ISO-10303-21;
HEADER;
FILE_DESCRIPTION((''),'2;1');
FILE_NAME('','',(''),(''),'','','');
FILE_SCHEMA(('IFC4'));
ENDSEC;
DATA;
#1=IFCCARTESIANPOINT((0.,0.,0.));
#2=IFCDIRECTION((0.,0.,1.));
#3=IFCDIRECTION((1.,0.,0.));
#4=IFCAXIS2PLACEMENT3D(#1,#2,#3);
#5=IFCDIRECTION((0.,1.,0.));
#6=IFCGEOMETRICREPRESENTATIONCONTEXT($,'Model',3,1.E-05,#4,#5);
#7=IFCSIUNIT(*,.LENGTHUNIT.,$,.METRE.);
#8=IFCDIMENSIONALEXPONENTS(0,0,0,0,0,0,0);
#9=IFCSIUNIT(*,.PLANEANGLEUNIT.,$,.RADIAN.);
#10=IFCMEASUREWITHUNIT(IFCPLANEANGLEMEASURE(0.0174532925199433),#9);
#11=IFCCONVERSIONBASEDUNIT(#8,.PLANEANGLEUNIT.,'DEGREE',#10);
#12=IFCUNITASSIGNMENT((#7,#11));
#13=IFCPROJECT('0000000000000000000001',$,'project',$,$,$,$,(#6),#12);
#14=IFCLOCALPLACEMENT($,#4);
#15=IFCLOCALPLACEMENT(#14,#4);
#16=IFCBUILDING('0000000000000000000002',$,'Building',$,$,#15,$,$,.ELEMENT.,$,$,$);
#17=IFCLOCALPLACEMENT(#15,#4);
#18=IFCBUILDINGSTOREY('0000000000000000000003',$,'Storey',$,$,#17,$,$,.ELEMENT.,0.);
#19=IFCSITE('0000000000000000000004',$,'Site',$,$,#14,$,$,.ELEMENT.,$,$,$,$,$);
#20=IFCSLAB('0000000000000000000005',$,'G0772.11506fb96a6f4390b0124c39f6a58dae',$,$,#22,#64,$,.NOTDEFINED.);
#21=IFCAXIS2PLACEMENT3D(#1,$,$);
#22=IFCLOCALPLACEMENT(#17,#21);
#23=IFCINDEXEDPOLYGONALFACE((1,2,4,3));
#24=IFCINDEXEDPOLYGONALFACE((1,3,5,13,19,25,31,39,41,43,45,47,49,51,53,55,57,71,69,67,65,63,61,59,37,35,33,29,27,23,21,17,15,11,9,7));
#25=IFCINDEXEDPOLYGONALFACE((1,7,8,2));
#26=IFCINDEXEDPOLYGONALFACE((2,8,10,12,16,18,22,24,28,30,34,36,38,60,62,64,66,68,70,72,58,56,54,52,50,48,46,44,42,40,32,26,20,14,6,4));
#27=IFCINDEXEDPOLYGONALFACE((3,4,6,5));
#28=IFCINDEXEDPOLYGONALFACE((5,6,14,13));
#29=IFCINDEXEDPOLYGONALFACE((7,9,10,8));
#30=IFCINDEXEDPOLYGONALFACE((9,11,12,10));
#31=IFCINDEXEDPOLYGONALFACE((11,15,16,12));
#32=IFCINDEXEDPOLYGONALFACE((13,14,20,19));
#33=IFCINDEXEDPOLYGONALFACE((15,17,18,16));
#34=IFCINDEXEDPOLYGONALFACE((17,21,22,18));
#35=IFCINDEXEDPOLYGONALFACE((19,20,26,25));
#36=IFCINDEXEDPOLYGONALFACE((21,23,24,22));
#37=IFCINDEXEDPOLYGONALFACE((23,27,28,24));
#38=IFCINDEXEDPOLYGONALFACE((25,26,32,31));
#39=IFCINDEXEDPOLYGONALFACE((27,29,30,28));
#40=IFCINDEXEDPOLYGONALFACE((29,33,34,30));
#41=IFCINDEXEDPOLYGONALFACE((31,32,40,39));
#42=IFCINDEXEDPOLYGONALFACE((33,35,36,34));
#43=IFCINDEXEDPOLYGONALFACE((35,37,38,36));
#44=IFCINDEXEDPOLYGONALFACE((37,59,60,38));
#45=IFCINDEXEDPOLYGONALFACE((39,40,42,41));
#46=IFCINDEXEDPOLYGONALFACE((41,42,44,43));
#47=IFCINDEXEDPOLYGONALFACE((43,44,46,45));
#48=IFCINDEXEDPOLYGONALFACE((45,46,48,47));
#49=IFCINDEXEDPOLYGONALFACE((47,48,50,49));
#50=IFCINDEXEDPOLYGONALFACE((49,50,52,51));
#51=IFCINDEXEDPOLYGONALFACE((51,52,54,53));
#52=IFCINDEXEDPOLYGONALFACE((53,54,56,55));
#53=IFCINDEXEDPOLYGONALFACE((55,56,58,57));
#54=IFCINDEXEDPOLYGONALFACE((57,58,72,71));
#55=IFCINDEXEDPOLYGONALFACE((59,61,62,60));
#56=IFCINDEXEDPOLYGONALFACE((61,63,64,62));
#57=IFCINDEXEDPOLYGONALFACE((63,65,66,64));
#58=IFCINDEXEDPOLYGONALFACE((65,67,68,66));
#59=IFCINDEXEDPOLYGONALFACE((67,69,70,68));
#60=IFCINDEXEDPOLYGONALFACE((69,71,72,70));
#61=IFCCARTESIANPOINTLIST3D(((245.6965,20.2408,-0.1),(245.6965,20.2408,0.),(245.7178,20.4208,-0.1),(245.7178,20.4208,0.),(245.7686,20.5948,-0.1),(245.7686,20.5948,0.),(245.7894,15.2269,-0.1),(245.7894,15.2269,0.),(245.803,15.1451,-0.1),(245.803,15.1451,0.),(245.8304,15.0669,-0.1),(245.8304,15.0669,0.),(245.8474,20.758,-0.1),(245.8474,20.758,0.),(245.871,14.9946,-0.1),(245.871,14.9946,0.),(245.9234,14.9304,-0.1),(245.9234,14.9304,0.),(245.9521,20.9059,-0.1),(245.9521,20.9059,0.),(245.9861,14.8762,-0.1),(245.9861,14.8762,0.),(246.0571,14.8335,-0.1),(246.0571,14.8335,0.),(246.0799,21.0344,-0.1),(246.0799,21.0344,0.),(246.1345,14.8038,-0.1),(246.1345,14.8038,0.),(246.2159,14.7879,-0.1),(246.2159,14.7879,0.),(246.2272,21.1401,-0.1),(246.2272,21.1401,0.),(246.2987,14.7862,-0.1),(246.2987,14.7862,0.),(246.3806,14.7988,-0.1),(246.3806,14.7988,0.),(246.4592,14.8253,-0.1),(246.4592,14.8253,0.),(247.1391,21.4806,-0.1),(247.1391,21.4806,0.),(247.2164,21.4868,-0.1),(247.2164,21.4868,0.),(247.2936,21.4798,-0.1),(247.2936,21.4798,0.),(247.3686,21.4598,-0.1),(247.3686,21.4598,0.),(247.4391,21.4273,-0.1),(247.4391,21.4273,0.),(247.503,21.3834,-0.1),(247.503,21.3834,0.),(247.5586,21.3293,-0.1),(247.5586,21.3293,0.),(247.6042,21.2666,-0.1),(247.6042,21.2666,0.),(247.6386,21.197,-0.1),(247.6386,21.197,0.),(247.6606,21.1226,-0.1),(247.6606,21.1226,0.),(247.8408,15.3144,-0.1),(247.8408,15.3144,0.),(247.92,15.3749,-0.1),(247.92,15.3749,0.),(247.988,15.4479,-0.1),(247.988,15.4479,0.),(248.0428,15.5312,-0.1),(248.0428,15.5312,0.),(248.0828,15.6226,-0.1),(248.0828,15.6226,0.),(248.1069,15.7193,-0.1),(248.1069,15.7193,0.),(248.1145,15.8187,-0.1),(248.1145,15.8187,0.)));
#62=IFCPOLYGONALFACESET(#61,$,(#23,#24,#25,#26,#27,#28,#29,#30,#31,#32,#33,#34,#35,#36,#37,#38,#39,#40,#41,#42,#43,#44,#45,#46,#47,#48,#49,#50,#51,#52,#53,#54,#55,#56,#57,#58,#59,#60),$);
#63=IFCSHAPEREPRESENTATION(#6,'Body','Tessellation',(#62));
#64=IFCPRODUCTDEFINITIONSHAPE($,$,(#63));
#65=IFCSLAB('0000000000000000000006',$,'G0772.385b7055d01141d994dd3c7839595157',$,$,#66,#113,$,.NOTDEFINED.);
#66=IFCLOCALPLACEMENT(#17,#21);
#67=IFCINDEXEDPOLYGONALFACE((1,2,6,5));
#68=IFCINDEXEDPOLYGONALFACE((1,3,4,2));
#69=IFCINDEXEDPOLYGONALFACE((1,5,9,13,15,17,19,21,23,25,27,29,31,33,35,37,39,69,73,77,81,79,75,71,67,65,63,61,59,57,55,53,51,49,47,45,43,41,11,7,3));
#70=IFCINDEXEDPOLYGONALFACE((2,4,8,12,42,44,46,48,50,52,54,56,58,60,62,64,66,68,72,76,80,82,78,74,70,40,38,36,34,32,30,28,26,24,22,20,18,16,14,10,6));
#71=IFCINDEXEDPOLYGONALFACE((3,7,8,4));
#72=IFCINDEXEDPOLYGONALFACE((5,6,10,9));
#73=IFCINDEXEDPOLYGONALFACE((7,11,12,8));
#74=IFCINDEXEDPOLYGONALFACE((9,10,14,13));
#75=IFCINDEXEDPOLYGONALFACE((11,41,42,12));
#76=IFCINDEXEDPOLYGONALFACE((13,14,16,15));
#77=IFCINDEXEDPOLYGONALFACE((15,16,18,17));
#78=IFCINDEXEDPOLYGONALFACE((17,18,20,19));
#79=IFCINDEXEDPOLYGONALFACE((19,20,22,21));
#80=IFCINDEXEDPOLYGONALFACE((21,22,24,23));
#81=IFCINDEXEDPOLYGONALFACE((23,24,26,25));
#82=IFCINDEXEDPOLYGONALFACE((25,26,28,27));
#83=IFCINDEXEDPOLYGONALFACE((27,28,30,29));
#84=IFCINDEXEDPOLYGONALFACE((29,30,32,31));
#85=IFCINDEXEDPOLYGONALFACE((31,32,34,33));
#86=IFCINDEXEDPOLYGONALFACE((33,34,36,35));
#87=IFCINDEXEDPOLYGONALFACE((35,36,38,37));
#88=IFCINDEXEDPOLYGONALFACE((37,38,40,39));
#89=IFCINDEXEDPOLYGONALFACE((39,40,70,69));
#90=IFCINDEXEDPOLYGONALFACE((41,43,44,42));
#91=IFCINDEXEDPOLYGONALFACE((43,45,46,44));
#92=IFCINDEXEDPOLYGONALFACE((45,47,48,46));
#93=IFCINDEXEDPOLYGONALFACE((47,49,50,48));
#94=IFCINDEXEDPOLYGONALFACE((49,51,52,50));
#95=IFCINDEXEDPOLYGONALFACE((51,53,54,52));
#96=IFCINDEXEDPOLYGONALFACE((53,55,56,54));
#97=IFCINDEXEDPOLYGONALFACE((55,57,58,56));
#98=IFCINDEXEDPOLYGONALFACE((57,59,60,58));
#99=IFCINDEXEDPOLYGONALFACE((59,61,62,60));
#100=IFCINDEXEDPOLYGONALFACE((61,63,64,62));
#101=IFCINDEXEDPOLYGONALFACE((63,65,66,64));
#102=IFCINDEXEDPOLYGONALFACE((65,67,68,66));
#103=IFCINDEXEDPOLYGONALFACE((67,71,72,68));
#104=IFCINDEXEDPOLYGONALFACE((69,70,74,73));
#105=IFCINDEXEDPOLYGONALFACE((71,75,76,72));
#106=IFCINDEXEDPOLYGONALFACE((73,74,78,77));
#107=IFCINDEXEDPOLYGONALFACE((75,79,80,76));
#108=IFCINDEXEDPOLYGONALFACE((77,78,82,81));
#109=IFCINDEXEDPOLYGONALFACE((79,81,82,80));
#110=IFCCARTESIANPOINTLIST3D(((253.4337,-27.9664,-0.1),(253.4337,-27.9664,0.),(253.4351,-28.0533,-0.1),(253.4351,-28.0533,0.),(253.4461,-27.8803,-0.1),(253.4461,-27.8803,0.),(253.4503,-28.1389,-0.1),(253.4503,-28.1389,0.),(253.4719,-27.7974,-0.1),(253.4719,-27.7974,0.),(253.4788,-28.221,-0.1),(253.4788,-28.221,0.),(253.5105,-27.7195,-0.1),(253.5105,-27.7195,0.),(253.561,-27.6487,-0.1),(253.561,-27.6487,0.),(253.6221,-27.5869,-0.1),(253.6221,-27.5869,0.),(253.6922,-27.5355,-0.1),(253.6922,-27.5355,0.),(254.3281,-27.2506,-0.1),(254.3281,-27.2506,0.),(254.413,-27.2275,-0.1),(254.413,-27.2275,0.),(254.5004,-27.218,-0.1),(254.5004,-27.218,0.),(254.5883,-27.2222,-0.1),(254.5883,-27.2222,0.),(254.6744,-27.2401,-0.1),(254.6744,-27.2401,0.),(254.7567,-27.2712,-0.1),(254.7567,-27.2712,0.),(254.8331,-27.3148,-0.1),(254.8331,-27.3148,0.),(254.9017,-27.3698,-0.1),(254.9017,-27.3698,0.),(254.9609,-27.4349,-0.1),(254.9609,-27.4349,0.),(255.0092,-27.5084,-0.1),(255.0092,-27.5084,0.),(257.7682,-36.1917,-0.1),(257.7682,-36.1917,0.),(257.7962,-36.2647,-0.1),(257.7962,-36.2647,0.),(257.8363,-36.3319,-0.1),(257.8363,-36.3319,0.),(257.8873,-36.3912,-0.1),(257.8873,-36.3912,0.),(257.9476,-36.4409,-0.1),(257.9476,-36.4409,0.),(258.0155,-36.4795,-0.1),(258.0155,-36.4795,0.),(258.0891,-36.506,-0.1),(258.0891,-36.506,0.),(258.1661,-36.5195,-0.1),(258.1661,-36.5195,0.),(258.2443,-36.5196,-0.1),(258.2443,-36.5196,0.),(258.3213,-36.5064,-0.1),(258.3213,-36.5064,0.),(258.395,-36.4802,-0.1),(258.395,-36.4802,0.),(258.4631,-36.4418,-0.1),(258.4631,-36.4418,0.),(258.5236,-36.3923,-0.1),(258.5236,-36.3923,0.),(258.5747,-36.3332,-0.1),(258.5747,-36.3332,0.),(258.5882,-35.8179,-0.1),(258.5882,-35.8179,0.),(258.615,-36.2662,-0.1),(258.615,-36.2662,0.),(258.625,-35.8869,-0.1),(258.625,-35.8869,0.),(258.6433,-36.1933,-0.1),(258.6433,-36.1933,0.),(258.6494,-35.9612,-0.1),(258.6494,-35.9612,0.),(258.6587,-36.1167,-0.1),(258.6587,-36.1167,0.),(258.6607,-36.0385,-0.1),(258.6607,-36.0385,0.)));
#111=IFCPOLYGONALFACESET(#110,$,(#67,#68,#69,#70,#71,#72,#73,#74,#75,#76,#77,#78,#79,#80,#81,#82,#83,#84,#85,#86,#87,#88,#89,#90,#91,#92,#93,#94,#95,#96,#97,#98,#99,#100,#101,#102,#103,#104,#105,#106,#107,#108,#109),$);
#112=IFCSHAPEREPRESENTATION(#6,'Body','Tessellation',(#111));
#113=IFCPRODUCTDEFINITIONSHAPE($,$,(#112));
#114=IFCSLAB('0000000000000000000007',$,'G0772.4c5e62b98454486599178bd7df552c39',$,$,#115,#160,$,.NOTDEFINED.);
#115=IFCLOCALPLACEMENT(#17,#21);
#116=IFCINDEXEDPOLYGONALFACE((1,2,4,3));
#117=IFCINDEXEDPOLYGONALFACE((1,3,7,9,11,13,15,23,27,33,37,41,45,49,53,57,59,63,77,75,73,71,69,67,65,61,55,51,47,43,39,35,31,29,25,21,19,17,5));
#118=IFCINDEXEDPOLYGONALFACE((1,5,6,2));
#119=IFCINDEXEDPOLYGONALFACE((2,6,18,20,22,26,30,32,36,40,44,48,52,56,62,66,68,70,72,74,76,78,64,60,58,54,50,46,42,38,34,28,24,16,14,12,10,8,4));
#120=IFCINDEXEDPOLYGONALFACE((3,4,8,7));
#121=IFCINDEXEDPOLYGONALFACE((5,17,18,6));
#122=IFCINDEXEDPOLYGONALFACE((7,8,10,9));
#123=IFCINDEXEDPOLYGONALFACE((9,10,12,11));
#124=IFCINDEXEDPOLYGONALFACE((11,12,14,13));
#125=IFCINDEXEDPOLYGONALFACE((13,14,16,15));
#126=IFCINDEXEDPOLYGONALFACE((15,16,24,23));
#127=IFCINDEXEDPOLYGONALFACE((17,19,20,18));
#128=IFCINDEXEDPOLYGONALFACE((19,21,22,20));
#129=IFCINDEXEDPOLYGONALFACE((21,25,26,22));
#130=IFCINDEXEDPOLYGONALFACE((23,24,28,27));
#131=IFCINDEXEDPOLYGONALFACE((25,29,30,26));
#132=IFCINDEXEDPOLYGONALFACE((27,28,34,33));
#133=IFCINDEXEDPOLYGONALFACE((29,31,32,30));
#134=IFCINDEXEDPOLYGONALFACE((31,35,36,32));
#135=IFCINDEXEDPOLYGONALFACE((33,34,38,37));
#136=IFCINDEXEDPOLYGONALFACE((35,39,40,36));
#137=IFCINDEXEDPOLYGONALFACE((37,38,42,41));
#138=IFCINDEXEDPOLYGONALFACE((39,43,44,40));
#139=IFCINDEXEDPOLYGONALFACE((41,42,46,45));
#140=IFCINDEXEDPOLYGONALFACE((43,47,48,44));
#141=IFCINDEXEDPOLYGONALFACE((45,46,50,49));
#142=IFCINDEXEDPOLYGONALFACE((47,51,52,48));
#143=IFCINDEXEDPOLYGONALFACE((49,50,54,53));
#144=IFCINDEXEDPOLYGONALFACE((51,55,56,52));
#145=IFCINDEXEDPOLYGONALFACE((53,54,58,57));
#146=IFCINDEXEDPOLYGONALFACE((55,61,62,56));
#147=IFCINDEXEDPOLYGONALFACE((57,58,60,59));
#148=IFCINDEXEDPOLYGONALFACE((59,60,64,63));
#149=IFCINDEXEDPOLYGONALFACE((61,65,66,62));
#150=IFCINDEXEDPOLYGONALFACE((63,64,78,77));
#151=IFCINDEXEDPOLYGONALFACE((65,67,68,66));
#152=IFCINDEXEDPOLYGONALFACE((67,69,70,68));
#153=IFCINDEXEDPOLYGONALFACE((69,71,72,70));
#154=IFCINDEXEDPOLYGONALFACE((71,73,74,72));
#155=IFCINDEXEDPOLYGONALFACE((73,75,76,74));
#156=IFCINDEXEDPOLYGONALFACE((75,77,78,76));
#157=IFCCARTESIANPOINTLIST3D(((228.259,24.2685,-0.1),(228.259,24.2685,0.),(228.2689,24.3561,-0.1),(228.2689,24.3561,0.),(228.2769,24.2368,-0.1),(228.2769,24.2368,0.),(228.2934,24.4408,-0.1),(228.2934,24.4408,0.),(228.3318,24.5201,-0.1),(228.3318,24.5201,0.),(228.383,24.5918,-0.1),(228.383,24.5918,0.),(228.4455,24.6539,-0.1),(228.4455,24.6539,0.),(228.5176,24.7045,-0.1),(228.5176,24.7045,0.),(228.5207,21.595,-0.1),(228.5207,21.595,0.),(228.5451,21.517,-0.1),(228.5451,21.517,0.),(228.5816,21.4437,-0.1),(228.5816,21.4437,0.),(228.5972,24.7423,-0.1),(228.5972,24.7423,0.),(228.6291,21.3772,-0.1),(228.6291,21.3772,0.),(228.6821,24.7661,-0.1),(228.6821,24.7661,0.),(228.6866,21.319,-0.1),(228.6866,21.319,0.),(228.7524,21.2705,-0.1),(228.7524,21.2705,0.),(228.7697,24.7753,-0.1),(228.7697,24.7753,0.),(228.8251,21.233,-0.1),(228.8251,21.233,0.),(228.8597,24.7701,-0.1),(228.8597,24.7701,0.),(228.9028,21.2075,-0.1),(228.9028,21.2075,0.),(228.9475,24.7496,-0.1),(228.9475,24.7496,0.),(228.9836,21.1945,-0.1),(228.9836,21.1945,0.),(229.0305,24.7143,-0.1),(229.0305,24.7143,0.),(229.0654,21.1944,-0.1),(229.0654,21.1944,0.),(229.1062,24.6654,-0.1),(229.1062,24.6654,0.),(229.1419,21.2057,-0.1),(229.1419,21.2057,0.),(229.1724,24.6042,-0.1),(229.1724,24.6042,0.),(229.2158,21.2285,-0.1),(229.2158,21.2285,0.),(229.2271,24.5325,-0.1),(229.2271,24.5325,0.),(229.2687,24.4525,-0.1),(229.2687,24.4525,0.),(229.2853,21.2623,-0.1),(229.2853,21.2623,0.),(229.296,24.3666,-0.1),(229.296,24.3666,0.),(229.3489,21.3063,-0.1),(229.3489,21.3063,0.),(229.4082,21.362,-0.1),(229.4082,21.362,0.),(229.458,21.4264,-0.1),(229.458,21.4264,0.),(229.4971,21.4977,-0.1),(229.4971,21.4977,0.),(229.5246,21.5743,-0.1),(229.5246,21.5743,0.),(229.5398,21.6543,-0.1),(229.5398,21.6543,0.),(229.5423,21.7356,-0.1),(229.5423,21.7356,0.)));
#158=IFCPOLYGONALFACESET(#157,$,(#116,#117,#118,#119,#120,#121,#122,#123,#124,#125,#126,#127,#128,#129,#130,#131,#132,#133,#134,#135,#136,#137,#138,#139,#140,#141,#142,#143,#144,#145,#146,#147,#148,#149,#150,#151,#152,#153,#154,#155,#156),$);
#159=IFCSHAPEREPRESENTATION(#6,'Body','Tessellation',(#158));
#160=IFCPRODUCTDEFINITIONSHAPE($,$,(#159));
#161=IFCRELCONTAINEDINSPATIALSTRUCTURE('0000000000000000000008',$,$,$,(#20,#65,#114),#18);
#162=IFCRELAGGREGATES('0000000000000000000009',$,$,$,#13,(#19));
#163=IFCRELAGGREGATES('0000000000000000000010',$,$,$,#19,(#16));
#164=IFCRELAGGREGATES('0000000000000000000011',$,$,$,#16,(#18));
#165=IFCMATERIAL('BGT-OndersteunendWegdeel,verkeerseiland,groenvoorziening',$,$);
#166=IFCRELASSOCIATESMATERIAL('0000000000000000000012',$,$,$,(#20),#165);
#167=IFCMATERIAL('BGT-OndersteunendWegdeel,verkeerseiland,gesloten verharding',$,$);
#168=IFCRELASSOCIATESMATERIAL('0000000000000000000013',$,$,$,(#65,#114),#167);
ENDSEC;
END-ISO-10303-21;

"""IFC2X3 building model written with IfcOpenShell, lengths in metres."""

from ifc_helpers import new_model, entity, si_unit, converted_unit, direction, frame, origin_with_axes, place, context, project, spatial, polyline, outline, extrude, material, element, save


model = new_model("IFC2X3")

# Units and contexts
model_context = context("Model", 3, precision=1e-05, world=origin_with_axes(), true_north=direction((0.0, 1.0, 0.0)))
ifc_project = project(units=[si_unit("LENGTHUNIT", "METRE"), converted_unit("PLANEANGLEUNIT", "DEGREE", entity("IfcPlaneAngleMeasure", 0.0174532925199433), si_unit("PLANEANGLEUNIT", "RADIAN"), dimensions=[0, 0, 0, 0, 0, 0, 0])], contexts=[model_context])

# Site, building, storey
site_placement = place(None, origin_with_axes())
site = spatial("IfcSite", under=ifc_project, at=site_placement, Name="Site", CompositionType="ELEMENT")
building_placement = place(site_placement, origin_with_axes())
building = spatial("IfcBuilding", under=site, at=building_placement, Name="Building", CompositionType="ELEMENT")
storey_placement = place(building_placement, origin_with_axes())
storey = spatial("IfcBuildingStorey", under=building, at=storey_placement, Name="Storey", CompositionType="ELEMENT", Elevation=0.0)

# Slabs
ifc_material_1 = material(Name="BGT-OndersteunendWegdeel,verkeerseiland,gesloten verharding")
ifc_material_2 = material(Name="BGT-OndersteunendWegdeel,verkeerseiland,groenvoorziening")
slab_1_placement = place(storey_placement, frame((0.0, 0.0, -0.1), z_axis=(0.0, 0.0, 1.0), x_axis=(1.0, 0.0, 0.0)))
element("IfcSlab", 1, at=slab_1_placement, inside=storey, material=ifc_material_2, Name="G0772.11506fb96a6f4390b0124c39f6a58dae", PredefinedType="NOTDEFINED", context=model_context, shape_type="SweptSolid", body=[
    extrude(outline(polyline([(245.6965, 20.2408), (245.7178, 20.4208), (245.7686, 20.5948), (245.8474, 20.758), (245.9521, 20.9059), (246.0799, 21.0344), (246.2272, 21.1401), (247.1391, 21.4806), (247.2164, 21.4868), (247.2936, 21.4798), (247.3686, 21.4598), (247.4391, 21.4273), (247.503, 21.3834), (247.5586, 21.3293), (247.6042, 21.2666), (247.6386, 21.197), (247.6606, 21.1226), (248.1145, 15.8187), (248.1069, 15.7193), (248.0828, 15.6226), (248.0428, 15.5312), (247.988, 15.4479), (247.92, 15.3749), (247.8408, 15.3144), (246.4592, 14.8253), (246.3806, 14.7988), (246.2987, 14.7862), (246.2159, 14.7879), (246.1345, 14.8038), (246.0571, 14.8335), (245.9861, 14.8762), (245.9234, 14.9304), (245.871, 14.9946), (245.8304, 15.0669), (245.803, 15.1451), (245.7894, 15.2269), (245.6965, 20.2408)])), origin_with_axes(), (0.0, 0.0, 1.0), 0.1),
])
slab_2_placement = place(storey_placement, frame((0.0, 0.0, -0.1), z_axis=(0.0, 0.0, 1.0), x_axis=(1.0, 0.0, 0.0)))
element("IfcSlab", 2, at=slab_2_placement, inside=storey, material=ifc_material_1, Name="G0772.385b7055d01141d994dd3c7839595157", PredefinedType="NOTDEFINED", context=model_context, shape_type="SweptSolid", body=[
    extrude(outline(polyline([(253.4788, -28.221), (253.4503, -28.1389), (253.4351, -28.0533), (253.4337, -27.9664), (253.4461, -27.8803), (253.4719, -27.7974), (253.5105, -27.7195), (253.561, -27.6487), (253.6221, -27.5869), (253.6922, -27.5355), (254.3281, -27.2506), (254.413, -27.2275), (254.5004, -27.218), (254.5883, -27.2222), (254.6744, -27.2401), (254.7567, -27.2712), (254.8331, -27.3148), (254.9017, -27.3698), (254.9609, -27.4349), (255.0092, -27.5084), (258.5882, -35.8179), (258.625, -35.8869), (258.6494, -35.9612), (258.6607, -36.0385), (258.6587, -36.1167), (258.6433, -36.1933), (258.615, -36.2662), (258.5747, -36.3332), (258.5236, -36.3923), (258.4631, -36.4418), (258.395, -36.4802), (258.3213, -36.5064), (258.2443, -36.5196), (258.1661, -36.5195), (258.0891, -36.506), (258.0155, -36.4795), (257.9476, -36.4409), (257.8873, -36.3912), (257.8363, -36.3319), (257.7962, -36.2647), (257.7682, -36.1917), (253.4788, -28.221)])), origin_with_axes(), (0.0, 0.0, 1.0), 0.1),
])
slab_3_placement = place(storey_placement, frame((0.0, 0.0, -0.1), z_axis=(0.0, 0.0, 1.0), x_axis=(1.0, 0.0, 0.0)))
element("IfcSlab", 3, at=slab_3_placement, inside=storey, material=ifc_material_1, Name="G0772.4c5e62b98454486599178bd7df552c39", PredefinedType="NOTDEFINED", context=model_context, shape_type="SweptSolid", body=[
    extrude(outline(polyline([(228.8597, 24.7701), (228.9475, 24.7496), (229.0305, 24.7143), (229.1062, 24.6654), (229.1724, 24.6042), (229.2271, 24.5325), (229.2687, 24.4525), (229.296, 24.3666), (229.5423, 21.7356), (229.5398, 21.6543), (229.5246, 21.5743), (229.4971, 21.4977), (229.458, 21.4264), (229.4082, 21.362), (229.3489, 21.3063), (229.2853, 21.2623), (229.2158, 21.2285), (229.1419, 21.2057), (229.0654, 21.1944), (228.9836, 21.1945), (228.9028, 21.2075), (228.8251, 21.233), (228.7524, 21.2705), (228.6866, 21.319), (228.6291, 21.3772), (228.5816, 21.4437), (228.5451, 21.517), (228.5207, 21.595), (228.2769, 24.2368), (228.259, 24.2685), (228.2689, 24.3561), (228.2934, 24.4408), (228.3318, 24.5201), (228.383, 24.5918), (228.4455, 24.6539), (228.5176, 24.7045), (228.5972, 24.7423), (228.6821, 24.7661), (228.7697, 24.7753), (228.8597, 24.7701)])), origin_with_axes(), (0.0, 0.0, 1.0), 0.1),
])

save(model, "model.ifc")
